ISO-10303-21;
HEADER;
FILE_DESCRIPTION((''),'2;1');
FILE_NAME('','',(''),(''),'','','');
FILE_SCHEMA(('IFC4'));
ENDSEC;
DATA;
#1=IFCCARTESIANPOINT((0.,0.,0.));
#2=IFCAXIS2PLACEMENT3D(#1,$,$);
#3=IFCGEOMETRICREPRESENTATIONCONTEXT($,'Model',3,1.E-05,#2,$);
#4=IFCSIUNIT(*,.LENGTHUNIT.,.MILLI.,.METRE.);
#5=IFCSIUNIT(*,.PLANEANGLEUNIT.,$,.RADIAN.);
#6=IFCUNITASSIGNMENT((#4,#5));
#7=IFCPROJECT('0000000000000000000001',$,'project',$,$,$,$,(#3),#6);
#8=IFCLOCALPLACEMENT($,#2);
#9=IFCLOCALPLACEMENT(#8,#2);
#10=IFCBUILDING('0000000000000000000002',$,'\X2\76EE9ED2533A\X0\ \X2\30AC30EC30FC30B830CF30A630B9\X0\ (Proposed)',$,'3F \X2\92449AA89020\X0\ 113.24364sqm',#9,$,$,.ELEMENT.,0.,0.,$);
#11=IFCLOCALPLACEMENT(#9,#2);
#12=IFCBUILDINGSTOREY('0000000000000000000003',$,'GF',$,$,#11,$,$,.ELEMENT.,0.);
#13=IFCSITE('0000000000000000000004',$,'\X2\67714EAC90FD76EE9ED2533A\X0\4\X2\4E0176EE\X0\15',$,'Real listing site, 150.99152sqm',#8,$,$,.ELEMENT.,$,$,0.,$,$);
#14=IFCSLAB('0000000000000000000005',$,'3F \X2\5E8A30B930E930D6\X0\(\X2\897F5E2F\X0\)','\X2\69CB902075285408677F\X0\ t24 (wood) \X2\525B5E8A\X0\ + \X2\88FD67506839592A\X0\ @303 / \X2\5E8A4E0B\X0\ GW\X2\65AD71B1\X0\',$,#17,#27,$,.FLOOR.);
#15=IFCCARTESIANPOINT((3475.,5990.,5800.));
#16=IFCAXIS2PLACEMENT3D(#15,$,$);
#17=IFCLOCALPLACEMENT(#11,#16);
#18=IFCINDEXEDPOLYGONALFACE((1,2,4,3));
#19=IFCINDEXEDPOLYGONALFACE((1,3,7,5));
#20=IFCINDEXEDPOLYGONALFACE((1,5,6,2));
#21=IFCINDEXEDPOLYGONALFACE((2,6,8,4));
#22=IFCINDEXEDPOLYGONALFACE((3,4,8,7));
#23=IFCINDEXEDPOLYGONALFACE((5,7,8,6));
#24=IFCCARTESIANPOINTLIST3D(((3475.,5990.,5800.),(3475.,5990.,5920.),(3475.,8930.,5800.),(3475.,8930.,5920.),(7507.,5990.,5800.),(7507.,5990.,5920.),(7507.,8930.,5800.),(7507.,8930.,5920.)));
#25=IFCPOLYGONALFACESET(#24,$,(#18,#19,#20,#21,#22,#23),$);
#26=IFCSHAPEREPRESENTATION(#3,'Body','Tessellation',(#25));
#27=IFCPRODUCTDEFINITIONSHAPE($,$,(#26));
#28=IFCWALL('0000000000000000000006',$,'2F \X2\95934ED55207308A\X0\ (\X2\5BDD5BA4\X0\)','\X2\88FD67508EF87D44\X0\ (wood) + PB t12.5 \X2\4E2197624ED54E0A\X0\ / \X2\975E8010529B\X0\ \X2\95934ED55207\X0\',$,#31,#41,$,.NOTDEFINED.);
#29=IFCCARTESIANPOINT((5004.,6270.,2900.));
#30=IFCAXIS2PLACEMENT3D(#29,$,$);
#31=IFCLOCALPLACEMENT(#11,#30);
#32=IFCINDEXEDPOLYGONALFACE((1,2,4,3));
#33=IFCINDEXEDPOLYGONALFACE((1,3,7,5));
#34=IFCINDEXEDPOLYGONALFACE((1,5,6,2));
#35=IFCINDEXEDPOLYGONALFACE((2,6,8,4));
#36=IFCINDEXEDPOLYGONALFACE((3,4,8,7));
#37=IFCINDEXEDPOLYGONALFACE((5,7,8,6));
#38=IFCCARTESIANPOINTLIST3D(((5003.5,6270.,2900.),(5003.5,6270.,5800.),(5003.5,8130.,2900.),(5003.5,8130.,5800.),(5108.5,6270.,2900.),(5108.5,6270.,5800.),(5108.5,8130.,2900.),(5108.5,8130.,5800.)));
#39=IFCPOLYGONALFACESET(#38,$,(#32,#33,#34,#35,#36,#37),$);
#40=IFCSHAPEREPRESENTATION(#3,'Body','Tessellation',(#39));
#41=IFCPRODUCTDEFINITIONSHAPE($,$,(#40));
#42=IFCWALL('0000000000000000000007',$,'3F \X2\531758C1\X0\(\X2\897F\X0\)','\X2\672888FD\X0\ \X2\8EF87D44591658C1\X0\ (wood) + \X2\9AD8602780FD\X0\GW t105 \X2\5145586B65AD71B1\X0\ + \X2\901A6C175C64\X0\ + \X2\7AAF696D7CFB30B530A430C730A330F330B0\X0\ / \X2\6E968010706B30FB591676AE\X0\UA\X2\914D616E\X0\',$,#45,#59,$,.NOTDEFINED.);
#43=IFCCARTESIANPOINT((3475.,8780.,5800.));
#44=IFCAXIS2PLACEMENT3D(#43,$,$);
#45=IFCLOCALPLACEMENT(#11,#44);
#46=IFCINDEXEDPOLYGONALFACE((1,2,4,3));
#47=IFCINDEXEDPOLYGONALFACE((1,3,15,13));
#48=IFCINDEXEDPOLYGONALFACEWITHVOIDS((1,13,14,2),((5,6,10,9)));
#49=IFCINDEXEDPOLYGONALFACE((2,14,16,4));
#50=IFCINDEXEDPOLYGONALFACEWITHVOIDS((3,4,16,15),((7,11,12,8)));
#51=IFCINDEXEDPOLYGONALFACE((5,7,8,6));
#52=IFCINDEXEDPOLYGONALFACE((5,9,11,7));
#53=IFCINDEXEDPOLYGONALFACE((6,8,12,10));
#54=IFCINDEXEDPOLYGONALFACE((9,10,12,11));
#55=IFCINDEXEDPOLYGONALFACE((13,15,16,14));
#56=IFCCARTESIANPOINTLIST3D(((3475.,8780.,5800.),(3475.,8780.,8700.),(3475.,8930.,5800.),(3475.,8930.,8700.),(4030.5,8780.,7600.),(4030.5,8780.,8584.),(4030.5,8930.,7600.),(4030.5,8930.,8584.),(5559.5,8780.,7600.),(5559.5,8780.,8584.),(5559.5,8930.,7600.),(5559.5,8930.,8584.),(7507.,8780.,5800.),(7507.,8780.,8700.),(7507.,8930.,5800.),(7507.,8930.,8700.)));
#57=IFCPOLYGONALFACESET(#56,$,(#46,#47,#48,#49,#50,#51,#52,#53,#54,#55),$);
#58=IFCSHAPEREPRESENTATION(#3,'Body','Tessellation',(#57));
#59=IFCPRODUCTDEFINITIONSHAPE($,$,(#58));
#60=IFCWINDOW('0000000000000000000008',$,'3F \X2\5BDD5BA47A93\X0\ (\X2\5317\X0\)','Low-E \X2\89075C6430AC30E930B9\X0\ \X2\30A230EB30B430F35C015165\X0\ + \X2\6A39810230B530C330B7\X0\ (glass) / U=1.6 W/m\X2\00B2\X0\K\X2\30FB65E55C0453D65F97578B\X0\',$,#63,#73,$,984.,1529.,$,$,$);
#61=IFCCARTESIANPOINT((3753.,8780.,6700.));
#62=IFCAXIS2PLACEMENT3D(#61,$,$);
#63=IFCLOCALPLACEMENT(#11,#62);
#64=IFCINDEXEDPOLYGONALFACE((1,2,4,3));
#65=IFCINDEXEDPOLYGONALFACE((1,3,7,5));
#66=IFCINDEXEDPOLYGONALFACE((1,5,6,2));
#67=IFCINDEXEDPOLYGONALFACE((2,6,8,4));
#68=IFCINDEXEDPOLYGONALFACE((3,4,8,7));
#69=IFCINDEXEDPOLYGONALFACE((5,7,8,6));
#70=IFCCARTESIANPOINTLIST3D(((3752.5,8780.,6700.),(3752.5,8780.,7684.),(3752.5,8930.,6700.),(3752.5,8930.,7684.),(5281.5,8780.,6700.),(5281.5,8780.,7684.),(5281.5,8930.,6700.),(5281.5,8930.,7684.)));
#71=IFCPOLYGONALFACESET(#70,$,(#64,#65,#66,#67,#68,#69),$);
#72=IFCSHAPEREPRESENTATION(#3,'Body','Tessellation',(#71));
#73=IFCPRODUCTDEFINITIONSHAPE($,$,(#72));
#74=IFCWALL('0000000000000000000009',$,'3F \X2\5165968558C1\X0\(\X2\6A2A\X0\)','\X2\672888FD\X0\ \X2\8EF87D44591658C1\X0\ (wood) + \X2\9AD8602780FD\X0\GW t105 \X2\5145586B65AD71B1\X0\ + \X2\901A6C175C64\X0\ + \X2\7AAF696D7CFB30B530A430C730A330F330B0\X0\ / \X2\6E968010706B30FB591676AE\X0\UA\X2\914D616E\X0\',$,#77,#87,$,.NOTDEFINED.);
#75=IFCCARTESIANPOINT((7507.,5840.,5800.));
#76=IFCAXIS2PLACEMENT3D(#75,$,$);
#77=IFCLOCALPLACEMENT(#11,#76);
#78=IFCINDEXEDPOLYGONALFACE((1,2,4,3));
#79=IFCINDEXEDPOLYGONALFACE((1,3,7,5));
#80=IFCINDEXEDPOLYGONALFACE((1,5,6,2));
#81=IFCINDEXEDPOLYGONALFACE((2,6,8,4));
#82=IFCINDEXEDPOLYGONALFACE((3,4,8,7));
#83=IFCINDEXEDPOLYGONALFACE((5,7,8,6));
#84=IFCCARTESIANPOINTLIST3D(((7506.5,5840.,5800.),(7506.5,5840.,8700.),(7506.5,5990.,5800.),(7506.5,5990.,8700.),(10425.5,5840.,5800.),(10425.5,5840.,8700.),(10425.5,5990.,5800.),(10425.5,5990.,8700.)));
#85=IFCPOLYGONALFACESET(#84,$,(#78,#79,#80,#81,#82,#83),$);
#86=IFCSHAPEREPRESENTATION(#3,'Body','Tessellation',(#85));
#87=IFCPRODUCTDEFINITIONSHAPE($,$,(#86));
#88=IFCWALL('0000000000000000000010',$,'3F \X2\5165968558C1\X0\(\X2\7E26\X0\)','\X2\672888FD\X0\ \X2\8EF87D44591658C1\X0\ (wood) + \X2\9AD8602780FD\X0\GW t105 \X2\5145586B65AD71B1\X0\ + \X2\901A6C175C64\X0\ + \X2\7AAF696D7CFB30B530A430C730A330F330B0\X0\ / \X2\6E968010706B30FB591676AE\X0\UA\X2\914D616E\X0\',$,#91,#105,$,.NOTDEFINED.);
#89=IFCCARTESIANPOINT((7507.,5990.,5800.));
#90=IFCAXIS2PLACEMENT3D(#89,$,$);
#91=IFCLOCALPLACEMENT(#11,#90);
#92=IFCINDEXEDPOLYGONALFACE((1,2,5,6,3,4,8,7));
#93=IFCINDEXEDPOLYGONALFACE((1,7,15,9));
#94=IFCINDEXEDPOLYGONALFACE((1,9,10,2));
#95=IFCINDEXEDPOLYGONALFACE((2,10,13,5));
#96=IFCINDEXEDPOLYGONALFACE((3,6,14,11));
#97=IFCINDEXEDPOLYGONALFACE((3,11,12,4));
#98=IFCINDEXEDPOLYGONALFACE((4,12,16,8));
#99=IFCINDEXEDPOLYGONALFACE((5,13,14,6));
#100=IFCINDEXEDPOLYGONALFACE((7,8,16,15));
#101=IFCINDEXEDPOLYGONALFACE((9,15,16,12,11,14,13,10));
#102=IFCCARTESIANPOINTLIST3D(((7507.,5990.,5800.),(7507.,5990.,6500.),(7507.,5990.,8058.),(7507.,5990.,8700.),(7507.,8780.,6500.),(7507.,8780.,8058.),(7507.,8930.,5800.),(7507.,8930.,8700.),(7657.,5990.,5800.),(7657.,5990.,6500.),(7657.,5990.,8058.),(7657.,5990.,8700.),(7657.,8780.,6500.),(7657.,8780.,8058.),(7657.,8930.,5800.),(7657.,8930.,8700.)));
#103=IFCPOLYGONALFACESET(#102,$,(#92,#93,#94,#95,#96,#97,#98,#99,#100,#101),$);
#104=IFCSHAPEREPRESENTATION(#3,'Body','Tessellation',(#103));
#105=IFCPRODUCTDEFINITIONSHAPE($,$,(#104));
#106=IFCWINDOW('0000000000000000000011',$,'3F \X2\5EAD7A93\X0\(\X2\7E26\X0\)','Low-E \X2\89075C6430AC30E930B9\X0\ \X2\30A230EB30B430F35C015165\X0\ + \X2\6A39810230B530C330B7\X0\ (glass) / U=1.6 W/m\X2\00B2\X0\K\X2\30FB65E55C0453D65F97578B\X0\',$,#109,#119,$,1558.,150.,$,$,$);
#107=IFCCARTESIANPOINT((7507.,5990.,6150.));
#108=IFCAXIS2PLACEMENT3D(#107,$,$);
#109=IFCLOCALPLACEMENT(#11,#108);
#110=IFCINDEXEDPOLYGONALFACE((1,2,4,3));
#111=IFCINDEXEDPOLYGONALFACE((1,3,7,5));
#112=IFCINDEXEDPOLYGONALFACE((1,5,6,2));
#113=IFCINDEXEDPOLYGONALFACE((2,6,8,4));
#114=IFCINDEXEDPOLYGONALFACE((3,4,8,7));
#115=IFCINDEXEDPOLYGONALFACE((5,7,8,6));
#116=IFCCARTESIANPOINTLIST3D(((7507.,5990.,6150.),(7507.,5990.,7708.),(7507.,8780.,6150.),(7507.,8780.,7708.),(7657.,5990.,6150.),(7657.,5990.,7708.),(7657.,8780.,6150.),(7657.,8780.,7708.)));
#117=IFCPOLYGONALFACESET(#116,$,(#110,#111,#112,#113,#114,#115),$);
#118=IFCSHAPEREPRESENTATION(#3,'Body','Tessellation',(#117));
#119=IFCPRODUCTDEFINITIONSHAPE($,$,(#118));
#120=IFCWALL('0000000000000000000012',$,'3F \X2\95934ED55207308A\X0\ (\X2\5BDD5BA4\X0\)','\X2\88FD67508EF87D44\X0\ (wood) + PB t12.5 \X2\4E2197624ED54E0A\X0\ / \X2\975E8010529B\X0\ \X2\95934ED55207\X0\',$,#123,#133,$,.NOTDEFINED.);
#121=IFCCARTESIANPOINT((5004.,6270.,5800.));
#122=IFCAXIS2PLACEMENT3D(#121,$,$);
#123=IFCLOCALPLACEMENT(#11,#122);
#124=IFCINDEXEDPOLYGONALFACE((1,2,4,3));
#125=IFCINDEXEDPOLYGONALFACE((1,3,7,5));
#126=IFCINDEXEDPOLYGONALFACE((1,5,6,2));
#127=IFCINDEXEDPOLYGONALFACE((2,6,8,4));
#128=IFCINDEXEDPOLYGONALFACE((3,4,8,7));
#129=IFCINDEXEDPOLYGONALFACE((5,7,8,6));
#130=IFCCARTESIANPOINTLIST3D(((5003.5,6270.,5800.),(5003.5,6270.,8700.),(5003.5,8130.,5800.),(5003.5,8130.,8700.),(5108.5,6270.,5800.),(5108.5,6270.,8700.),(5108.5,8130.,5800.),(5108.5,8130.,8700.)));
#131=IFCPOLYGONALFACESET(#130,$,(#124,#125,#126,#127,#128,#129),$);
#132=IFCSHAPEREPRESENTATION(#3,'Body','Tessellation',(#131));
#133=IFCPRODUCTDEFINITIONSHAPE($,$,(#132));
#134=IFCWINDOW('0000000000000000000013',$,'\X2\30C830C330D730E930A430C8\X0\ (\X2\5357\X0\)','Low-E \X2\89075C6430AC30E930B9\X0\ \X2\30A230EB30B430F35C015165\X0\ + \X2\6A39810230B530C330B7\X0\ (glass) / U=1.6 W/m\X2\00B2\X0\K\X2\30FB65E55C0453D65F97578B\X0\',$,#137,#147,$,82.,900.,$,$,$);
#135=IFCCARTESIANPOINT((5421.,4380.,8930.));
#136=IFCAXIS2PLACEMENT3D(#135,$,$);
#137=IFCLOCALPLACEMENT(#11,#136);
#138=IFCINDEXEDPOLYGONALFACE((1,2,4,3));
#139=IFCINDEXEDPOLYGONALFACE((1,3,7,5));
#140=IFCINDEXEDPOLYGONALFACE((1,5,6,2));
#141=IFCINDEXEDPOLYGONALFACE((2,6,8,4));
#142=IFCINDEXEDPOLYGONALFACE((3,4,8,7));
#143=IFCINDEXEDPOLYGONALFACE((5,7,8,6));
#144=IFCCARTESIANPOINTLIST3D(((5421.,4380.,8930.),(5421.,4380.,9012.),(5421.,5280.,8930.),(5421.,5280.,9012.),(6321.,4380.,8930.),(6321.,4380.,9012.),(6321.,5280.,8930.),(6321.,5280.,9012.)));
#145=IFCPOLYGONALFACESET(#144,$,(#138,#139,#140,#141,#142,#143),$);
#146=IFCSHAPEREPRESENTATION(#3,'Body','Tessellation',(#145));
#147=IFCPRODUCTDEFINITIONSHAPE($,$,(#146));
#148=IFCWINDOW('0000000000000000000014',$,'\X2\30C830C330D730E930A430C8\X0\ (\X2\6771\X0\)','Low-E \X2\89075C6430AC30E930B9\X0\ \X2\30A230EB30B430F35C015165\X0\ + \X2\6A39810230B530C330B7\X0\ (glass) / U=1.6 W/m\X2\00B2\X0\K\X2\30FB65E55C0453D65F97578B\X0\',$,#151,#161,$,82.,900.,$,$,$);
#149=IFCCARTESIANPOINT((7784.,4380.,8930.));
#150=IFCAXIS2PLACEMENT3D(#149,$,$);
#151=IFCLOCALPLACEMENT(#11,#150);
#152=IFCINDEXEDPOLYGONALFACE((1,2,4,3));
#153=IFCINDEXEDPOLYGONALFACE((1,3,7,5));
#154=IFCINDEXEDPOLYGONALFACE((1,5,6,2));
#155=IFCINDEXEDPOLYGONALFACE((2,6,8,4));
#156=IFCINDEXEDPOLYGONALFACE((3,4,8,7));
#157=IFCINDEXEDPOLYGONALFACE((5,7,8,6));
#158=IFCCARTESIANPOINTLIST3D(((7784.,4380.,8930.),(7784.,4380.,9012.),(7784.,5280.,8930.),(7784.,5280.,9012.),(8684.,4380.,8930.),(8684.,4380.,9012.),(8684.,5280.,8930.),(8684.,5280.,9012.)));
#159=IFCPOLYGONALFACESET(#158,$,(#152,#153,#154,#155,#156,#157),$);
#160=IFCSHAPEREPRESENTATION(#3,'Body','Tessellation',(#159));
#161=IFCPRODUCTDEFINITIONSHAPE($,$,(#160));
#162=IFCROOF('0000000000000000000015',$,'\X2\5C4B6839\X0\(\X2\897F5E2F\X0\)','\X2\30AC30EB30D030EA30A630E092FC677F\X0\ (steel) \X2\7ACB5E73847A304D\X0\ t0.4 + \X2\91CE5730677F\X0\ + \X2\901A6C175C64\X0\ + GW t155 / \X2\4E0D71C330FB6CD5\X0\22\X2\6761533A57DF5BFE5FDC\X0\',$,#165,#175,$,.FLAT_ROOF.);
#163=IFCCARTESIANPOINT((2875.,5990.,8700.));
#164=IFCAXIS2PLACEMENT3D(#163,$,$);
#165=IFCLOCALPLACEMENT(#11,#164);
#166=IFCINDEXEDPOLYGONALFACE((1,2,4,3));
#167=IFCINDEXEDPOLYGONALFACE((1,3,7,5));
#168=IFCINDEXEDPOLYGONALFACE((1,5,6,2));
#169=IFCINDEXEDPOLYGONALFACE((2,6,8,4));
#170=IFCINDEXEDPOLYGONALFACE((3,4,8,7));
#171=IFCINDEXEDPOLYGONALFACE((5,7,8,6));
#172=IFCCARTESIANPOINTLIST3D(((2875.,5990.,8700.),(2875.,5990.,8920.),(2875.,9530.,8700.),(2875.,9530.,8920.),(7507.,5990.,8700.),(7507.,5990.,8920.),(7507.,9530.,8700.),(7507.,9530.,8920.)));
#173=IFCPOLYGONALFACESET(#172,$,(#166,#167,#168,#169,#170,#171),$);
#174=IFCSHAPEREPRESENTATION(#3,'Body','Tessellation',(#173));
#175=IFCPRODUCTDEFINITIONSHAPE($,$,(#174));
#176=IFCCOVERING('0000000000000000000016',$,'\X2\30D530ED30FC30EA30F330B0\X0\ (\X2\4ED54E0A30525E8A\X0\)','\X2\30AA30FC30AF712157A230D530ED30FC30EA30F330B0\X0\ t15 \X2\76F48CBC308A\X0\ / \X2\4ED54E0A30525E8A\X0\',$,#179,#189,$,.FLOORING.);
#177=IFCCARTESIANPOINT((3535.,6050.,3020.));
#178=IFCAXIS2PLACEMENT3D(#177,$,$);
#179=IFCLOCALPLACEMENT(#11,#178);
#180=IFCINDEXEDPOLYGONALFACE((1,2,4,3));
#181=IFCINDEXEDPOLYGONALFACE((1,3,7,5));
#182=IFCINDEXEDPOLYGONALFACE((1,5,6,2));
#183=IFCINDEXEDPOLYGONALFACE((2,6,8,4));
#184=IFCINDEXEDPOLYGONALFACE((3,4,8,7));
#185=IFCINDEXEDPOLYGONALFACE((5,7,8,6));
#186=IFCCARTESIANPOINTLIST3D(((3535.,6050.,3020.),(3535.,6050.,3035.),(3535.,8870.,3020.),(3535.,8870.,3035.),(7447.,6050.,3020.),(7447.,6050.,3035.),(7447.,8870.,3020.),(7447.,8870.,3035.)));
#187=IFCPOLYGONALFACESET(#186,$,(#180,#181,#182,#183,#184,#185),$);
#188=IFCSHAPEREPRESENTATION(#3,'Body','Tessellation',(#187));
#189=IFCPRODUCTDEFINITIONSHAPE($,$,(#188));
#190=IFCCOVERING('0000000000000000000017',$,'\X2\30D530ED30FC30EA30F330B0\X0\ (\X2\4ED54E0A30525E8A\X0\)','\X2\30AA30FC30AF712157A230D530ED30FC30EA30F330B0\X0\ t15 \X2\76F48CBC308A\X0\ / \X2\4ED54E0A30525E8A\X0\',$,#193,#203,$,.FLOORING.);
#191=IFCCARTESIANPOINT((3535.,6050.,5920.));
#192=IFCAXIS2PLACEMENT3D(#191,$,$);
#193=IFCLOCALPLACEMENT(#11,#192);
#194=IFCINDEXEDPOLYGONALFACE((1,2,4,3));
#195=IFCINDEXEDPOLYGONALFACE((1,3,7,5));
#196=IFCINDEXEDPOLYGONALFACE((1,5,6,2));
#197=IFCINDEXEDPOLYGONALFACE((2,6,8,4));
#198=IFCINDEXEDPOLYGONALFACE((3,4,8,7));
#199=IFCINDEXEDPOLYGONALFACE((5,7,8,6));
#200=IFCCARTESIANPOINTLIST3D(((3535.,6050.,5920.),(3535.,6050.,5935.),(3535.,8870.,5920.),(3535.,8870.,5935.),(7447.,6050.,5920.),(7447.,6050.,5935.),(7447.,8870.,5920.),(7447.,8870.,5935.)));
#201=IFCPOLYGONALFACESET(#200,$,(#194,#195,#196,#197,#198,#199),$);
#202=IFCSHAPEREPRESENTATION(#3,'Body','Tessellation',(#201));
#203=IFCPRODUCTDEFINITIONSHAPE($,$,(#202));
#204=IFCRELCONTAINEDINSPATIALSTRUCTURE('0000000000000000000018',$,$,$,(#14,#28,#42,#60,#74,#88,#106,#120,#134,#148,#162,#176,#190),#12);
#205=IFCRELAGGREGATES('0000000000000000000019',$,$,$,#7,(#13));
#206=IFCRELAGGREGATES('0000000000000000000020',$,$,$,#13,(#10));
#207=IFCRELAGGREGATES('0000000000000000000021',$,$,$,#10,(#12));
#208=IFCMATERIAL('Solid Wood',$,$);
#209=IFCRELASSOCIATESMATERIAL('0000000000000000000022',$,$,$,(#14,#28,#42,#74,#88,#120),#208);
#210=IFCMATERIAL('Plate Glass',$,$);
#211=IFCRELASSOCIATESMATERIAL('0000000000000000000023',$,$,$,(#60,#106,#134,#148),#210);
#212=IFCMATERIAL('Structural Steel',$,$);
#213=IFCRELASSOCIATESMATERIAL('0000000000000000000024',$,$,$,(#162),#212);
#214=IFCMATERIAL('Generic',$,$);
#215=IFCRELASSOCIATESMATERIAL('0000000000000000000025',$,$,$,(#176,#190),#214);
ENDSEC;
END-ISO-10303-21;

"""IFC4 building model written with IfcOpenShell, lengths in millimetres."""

from ifc_helpers import new_model, si_unit, frame, frame_2d, origin, place, context, project, spatial, rectangle, extrude, material, element, fill, save


model = new_model("IFC4")

# Units and contexts
model_context = context("Model", 3, precision=1e-05, world=origin())
ifc_project = project(units=[si_unit("LENGTHUNIT", "METRE", prefix="MILLI"), si_unit("PLANEANGLEUNIT", "RADIAN")], contexts=[model_context])

# Site, building, storey
site_placement = place(None, origin())
site = spatial("IfcSite", under=ifc_project, at=site_placement, Name="東京都目黒区4丁目15", ObjectType="Real listing site, 150.99152sqm", CompositionType="ELEMENT", RefElevation=0.0)
building_placement = place(site_placement, origin())
building = spatial("IfcBuilding", under=site, at=building_placement, Name="目黒区 ガレージハウス (Proposed)", ObjectType="3F 鉄骨造 113.24364sqm", CompositionType="ELEMENT", ElevationOfRefHeight=0.0, ElevationOfTerrain=0.0)
storey_placement = place(building_placement, origin())
storey = spatial("IfcBuildingStorey", under=building, at=storey_placement, Name="GF", CompositionType="ELEMENT", Elevation=0.0)

# Slab
ifc_material_1 = material(Name="Solid Wood")
slab_placement = place(storey_placement, frame((3475.0, 5990.0, 5800.0)))
element("IfcSlab", 1, at=slab_placement, inside=storey, material=ifc_material_1, Name="3F 床スラブ(西帯)", Description="構造用合板 t24 (wood) 剛床 + 製材根太 @303 / 床下 GW断熱", PredefinedType="FLOOR", context=model_context, shape_type="SweptSolid", body=[
    extrude(rectangle(XDim=4032.0, YDim=2940.0, at=frame_2d((2016.0, 1470.0))), frame((3475.0, 5990.0, 5800.0)), (0.0, 0.0, 1.0), 120.0),
])

# Wall
wall_1_placement = place(storey_placement, frame((5004.0, 6270.0, 2900.0)))
element("IfcWall", 2, at=wall_1_placement, inside=storey, material=ifc_material_1, Name="2F 間仕切り (寝室)", Description="製材軸組 (wood) + PB t12.5 両面仕上 / 非耐力 間仕切", PredefinedType="NOTDEFINED", context=model_context, shape_type="SweptSolid", body=[
    extrude(rectangle(XDim=105.0, YDim=1860.0, at=frame_2d((52.0, 930.0))), frame((5004.0, 6270.0, 2900.0)), (0.0, 0.0, 1.0), 2900.0),
])

# Wall, opening, window
wall_2_placement = place(storey_placement, frame((3475.0, 8780.0, 5800.0)))
wall_2 = element("IfcWall", 3, at=wall_2_placement, inside=storey, material=ifc_material_1, Name="3F 北壁(西)", Description="木製 軸組外壁 (wood) + 高性能GW t105 充填断熱 + 通気層 + 窯業系サイディング / 準耐火・外皮UA配慮", PredefinedType="NOTDEFINED", context=model_context, shape_type="SweptSolid", body=[
    extrude(rectangle(XDim=4032.0, YDim=150.0, at=frame_2d((2016.0, 75.0))), frame((3475.0, 8780.0, 5800.0)), (0.0, 0.0, 1.0), 2900.0),
])
opening_1_placement = place(storey_placement, frame((3753.0, 8780.0, 6700.0)))
opening_1 = element("IfcOpeningElement", 4, at=opening_1_placement, cuts=wall_2, PredefinedType="NOTDEFINED", context=model_context, shape_type="SweptSolid", body=[
    extrude(rectangle(XDim=1529.0, YDim=150.0, at=frame_2d((764.0, 75.0))), frame((3753.0, 8780.0, 6700.0)), (0.0, 0.0, 1.0), 984.0),
])
ifc_material_2 = material(Name="Plate Glass")
window_1_placement = place(storey_placement, frame((3753.0, 8780.0, 6700.0)))
window_1 = element("IfcWindow", 5, at=window_1_placement, inside=storey, material=ifc_material_2, Name="3F 寝室窓 (北)", Description="Low-E 複層ガラス アルゴン封入 + 樹脂サッシ (glass) / U=1.6 W/m²K・日射取得型", OverallHeight=984.0, OverallWidth=1529.0, context=model_context, shape_type="SweptSolid", body=[
    extrude(rectangle(XDim=1529.0, YDim=150.0, at=frame_2d((764.0, 75.0))), frame((3753.0, 8780.0, 6700.0)), (0.0, 0.0, 1.0), 984.0),
])
fill(opening_1, window_1)

# Wall
wall_3_placement = place(storey_placement, frame((7507.0, 5840.0, 5800.0)))
element("IfcWall", 6, at=wall_3_placement, inside=storey, material=ifc_material_1, Name="3F 入隅壁(横)", Description="木製 軸組外壁 (wood) + 高性能GW t105 充填断熱 + 通気層 + 窯業系サイディング / 準耐火・外皮UA配慮", PredefinedType="NOTDEFINED", context=model_context, shape_type="SweptSolid", body=[
    extrude(rectangle(XDim=2919.0, YDim=150.0, at=frame_2d((1459.0, 75.0))), frame((7507.0, 5840.0, 5800.0)), (0.0, 0.0, 1.0), 2900.0),
])

# Wall, opening, window
wall_4_placement = place(storey_placement, frame((7507.0, 5990.0, 5800.0)))
wall_4 = element("IfcWall", 7, at=wall_4_placement, inside=storey, material=ifc_material_1, Name="3F 入隅壁(縦)", Description="木製 軸組外壁 (wood) + 高性能GW t105 充填断熱 + 通気層 + 窯業系サイディング / 準耐火・外皮UA配慮", PredefinedType="NOTDEFINED", context=model_context, shape_type="SweptSolid", body=[
    extrude(rectangle(XDim=150.0, YDim=2940.0, at=frame_2d((75.0, 1470.0))), frame((7507.0, 5990.0, 5800.0)), (0.0, 0.0, 1.0), 2900.0),
])
opening_2_placement = place(storey_placement, frame((7507.0, 5990.0, 6150.0)))
opening_2 = element("IfcOpeningElement", 8, at=opening_2_placement, cuts=wall_4, PredefinedType="NOTDEFINED", context=model_context, shape_type="SweptSolid", body=[
    extrude(rectangle(XDim=150.0, YDim=2790.0, at=frame_2d((75.0, 1395.0))), frame((7507.0, 5990.0, 6150.0)), (0.0, 0.0, 1.0), 1558.0),
])
window_2_placement = place(storey_placement, frame((7507.0, 5990.0, 6150.0)))
window_2 = element("IfcWindow", 9, at=window_2_placement, inside=storey, material=ifc_material_2, Name="3F 庭窓(縦)", Description="Low-E 複層ガラス アルゴン封入 + 樹脂サッシ (glass) / U=1.6 W/m²K・日射取得型", OverallHeight=1558.0, OverallWidth=150.0, context=model_context, shape_type="SweptSolid", body=[
    extrude(rectangle(XDim=150.0, YDim=2790.0, at=frame_2d((75.0, 1395.0))), frame((7507.0, 5990.0, 6150.0)), (0.0, 0.0, 1.0), 1558.0),
])
fill(opening_2, window_2)

# Wall
wall_5_placement = place(storey_placement, frame((5004.0, 6270.0, 5800.0)))
element("IfcWall", 10, at=wall_5_placement, inside=storey, material=ifc_material_1, Name="3F 間仕切り (寝室)", Description="製材軸組 (wood) + PB t12.5 両面仕上 / 非耐力 間仕切", PredefinedType="NOTDEFINED", context=model_context, shape_type="SweptSolid", body=[
    extrude(rectangle(XDim=105.0, YDim=1860.0, at=frame_2d((52.0, 930.0))), frame((5004.0, 6270.0, 5800.0)), (0.0, 0.0, 1.0), 2900.0),
])

# Windows
window_3_placement = place(storey_placement, frame((5421.0, 4380.0, 8930.0)))
element("IfcWindow", 11, at=window_3_placement, inside=storey, material=ifc_material_2, Name="トップライト (南)", Description="Low-E 複層ガラス アルゴン封入 + 樹脂サッシ (glass) / U=1.6 W/m²K・日射取得型", OverallHeight=82.0, OverallWidth=900.0, context=model_context, shape_type="SweptSolid", body=[
    extrude(rectangle(XDim=900.0, YDim=900.0, at=frame_2d((450.0, 450.0))), frame((5421.0, 4380.0, 8930.0)), (0.0, 0.0, 1.0), 82.0),
])
window_4_placement = place(storey_placement, frame((7784.0, 4380.0, 8930.0)))
element("IfcWindow", 12, at=window_4_placement, inside=storey, material=ifc_material_2, Name="トップライト (東)", Description="Low-E 複層ガラス アルゴン封入 + 樹脂サッシ (glass) / U=1.6 W/m²K・日射取得型", OverallHeight=82.0, OverallWidth=900.0, context=model_context, shape_type="SweptSolid", body=[
    extrude(rectangle(XDim=900.0, YDim=900.0, at=frame_2d((450.0, 450.0))), frame((7784.0, 4380.0, 8930.0)), (0.0, 0.0, 1.0), 82.0),
])

# Roof
ifc_material_3 = material(Name="Structural Steel")
for number, where, name in (
    (13, (2875.0, 5990.0, 8700.0), "屋根(西帯)"),
):
    element("IfcRoof", number, at=place(storey_placement, frame(where)), inside=storey, material=ifc_material_3, Name=name, Description="ガルバリウム鋼板 (steel) 立平葺き t0.4 + 野地板 + 通気層 + GW t155 / 不燃・法22条区域対応", PredefinedType="FLAT_ROOF", context=model_context, shape_type="SweptSolid", body=[
        extrude(rectangle(XDim=4632.0, YDim=3540.0, at=frame_2d((2316.0, 1770.0))), frame((2875.0, 5990.0, 8700.0)), (0.0, 0.0, 1.0), 220.0),
    ])

# Coverings
ifc_material_4 = material(Name="Generic")
covering_1_placement = place(storey_placement, frame((3535.0, 6050.0, 3020.0)))
element("IfcCovering", 14, at=covering_1_placement, inside=storey, material=ifc_material_4, Name="フローリング (仕上げ床)", Description="オーク無垢フローリング t15 直貼り / 仕上げ床", PredefinedType="FLOORING", context=model_context, shape_type="SweptSolid", body=[
    extrude(rectangle(XDim=3912.0, YDim=2820.0, at=frame_2d((1956.0, 1410.0))), frame((3535.0, 6050.0, 3020.0)), (0.0, 0.0, 1.0), 15.0),
])
covering_2_placement = place(storey_placement, frame((3535.0, 6050.0, 5920.0)))
element("IfcCovering", 15, at=covering_2_placement, inside=storey, material=ifc_material_4, Name="フローリング (仕上げ床)", Description="オーク無垢フローリング t15 直貼り / 仕上げ床", PredefinedType="FLOORING", context=model_context, shape_type="SweptSolid", body=[
    extrude(rectangle(XDim=3912.0, YDim=2820.0, at=frame_2d((1956.0, 1410.0))), frame((3535.0, 6050.0, 5920.0)), (0.0, 0.0, 1.0), 15.0),
])

save(model, "model.ifc")
